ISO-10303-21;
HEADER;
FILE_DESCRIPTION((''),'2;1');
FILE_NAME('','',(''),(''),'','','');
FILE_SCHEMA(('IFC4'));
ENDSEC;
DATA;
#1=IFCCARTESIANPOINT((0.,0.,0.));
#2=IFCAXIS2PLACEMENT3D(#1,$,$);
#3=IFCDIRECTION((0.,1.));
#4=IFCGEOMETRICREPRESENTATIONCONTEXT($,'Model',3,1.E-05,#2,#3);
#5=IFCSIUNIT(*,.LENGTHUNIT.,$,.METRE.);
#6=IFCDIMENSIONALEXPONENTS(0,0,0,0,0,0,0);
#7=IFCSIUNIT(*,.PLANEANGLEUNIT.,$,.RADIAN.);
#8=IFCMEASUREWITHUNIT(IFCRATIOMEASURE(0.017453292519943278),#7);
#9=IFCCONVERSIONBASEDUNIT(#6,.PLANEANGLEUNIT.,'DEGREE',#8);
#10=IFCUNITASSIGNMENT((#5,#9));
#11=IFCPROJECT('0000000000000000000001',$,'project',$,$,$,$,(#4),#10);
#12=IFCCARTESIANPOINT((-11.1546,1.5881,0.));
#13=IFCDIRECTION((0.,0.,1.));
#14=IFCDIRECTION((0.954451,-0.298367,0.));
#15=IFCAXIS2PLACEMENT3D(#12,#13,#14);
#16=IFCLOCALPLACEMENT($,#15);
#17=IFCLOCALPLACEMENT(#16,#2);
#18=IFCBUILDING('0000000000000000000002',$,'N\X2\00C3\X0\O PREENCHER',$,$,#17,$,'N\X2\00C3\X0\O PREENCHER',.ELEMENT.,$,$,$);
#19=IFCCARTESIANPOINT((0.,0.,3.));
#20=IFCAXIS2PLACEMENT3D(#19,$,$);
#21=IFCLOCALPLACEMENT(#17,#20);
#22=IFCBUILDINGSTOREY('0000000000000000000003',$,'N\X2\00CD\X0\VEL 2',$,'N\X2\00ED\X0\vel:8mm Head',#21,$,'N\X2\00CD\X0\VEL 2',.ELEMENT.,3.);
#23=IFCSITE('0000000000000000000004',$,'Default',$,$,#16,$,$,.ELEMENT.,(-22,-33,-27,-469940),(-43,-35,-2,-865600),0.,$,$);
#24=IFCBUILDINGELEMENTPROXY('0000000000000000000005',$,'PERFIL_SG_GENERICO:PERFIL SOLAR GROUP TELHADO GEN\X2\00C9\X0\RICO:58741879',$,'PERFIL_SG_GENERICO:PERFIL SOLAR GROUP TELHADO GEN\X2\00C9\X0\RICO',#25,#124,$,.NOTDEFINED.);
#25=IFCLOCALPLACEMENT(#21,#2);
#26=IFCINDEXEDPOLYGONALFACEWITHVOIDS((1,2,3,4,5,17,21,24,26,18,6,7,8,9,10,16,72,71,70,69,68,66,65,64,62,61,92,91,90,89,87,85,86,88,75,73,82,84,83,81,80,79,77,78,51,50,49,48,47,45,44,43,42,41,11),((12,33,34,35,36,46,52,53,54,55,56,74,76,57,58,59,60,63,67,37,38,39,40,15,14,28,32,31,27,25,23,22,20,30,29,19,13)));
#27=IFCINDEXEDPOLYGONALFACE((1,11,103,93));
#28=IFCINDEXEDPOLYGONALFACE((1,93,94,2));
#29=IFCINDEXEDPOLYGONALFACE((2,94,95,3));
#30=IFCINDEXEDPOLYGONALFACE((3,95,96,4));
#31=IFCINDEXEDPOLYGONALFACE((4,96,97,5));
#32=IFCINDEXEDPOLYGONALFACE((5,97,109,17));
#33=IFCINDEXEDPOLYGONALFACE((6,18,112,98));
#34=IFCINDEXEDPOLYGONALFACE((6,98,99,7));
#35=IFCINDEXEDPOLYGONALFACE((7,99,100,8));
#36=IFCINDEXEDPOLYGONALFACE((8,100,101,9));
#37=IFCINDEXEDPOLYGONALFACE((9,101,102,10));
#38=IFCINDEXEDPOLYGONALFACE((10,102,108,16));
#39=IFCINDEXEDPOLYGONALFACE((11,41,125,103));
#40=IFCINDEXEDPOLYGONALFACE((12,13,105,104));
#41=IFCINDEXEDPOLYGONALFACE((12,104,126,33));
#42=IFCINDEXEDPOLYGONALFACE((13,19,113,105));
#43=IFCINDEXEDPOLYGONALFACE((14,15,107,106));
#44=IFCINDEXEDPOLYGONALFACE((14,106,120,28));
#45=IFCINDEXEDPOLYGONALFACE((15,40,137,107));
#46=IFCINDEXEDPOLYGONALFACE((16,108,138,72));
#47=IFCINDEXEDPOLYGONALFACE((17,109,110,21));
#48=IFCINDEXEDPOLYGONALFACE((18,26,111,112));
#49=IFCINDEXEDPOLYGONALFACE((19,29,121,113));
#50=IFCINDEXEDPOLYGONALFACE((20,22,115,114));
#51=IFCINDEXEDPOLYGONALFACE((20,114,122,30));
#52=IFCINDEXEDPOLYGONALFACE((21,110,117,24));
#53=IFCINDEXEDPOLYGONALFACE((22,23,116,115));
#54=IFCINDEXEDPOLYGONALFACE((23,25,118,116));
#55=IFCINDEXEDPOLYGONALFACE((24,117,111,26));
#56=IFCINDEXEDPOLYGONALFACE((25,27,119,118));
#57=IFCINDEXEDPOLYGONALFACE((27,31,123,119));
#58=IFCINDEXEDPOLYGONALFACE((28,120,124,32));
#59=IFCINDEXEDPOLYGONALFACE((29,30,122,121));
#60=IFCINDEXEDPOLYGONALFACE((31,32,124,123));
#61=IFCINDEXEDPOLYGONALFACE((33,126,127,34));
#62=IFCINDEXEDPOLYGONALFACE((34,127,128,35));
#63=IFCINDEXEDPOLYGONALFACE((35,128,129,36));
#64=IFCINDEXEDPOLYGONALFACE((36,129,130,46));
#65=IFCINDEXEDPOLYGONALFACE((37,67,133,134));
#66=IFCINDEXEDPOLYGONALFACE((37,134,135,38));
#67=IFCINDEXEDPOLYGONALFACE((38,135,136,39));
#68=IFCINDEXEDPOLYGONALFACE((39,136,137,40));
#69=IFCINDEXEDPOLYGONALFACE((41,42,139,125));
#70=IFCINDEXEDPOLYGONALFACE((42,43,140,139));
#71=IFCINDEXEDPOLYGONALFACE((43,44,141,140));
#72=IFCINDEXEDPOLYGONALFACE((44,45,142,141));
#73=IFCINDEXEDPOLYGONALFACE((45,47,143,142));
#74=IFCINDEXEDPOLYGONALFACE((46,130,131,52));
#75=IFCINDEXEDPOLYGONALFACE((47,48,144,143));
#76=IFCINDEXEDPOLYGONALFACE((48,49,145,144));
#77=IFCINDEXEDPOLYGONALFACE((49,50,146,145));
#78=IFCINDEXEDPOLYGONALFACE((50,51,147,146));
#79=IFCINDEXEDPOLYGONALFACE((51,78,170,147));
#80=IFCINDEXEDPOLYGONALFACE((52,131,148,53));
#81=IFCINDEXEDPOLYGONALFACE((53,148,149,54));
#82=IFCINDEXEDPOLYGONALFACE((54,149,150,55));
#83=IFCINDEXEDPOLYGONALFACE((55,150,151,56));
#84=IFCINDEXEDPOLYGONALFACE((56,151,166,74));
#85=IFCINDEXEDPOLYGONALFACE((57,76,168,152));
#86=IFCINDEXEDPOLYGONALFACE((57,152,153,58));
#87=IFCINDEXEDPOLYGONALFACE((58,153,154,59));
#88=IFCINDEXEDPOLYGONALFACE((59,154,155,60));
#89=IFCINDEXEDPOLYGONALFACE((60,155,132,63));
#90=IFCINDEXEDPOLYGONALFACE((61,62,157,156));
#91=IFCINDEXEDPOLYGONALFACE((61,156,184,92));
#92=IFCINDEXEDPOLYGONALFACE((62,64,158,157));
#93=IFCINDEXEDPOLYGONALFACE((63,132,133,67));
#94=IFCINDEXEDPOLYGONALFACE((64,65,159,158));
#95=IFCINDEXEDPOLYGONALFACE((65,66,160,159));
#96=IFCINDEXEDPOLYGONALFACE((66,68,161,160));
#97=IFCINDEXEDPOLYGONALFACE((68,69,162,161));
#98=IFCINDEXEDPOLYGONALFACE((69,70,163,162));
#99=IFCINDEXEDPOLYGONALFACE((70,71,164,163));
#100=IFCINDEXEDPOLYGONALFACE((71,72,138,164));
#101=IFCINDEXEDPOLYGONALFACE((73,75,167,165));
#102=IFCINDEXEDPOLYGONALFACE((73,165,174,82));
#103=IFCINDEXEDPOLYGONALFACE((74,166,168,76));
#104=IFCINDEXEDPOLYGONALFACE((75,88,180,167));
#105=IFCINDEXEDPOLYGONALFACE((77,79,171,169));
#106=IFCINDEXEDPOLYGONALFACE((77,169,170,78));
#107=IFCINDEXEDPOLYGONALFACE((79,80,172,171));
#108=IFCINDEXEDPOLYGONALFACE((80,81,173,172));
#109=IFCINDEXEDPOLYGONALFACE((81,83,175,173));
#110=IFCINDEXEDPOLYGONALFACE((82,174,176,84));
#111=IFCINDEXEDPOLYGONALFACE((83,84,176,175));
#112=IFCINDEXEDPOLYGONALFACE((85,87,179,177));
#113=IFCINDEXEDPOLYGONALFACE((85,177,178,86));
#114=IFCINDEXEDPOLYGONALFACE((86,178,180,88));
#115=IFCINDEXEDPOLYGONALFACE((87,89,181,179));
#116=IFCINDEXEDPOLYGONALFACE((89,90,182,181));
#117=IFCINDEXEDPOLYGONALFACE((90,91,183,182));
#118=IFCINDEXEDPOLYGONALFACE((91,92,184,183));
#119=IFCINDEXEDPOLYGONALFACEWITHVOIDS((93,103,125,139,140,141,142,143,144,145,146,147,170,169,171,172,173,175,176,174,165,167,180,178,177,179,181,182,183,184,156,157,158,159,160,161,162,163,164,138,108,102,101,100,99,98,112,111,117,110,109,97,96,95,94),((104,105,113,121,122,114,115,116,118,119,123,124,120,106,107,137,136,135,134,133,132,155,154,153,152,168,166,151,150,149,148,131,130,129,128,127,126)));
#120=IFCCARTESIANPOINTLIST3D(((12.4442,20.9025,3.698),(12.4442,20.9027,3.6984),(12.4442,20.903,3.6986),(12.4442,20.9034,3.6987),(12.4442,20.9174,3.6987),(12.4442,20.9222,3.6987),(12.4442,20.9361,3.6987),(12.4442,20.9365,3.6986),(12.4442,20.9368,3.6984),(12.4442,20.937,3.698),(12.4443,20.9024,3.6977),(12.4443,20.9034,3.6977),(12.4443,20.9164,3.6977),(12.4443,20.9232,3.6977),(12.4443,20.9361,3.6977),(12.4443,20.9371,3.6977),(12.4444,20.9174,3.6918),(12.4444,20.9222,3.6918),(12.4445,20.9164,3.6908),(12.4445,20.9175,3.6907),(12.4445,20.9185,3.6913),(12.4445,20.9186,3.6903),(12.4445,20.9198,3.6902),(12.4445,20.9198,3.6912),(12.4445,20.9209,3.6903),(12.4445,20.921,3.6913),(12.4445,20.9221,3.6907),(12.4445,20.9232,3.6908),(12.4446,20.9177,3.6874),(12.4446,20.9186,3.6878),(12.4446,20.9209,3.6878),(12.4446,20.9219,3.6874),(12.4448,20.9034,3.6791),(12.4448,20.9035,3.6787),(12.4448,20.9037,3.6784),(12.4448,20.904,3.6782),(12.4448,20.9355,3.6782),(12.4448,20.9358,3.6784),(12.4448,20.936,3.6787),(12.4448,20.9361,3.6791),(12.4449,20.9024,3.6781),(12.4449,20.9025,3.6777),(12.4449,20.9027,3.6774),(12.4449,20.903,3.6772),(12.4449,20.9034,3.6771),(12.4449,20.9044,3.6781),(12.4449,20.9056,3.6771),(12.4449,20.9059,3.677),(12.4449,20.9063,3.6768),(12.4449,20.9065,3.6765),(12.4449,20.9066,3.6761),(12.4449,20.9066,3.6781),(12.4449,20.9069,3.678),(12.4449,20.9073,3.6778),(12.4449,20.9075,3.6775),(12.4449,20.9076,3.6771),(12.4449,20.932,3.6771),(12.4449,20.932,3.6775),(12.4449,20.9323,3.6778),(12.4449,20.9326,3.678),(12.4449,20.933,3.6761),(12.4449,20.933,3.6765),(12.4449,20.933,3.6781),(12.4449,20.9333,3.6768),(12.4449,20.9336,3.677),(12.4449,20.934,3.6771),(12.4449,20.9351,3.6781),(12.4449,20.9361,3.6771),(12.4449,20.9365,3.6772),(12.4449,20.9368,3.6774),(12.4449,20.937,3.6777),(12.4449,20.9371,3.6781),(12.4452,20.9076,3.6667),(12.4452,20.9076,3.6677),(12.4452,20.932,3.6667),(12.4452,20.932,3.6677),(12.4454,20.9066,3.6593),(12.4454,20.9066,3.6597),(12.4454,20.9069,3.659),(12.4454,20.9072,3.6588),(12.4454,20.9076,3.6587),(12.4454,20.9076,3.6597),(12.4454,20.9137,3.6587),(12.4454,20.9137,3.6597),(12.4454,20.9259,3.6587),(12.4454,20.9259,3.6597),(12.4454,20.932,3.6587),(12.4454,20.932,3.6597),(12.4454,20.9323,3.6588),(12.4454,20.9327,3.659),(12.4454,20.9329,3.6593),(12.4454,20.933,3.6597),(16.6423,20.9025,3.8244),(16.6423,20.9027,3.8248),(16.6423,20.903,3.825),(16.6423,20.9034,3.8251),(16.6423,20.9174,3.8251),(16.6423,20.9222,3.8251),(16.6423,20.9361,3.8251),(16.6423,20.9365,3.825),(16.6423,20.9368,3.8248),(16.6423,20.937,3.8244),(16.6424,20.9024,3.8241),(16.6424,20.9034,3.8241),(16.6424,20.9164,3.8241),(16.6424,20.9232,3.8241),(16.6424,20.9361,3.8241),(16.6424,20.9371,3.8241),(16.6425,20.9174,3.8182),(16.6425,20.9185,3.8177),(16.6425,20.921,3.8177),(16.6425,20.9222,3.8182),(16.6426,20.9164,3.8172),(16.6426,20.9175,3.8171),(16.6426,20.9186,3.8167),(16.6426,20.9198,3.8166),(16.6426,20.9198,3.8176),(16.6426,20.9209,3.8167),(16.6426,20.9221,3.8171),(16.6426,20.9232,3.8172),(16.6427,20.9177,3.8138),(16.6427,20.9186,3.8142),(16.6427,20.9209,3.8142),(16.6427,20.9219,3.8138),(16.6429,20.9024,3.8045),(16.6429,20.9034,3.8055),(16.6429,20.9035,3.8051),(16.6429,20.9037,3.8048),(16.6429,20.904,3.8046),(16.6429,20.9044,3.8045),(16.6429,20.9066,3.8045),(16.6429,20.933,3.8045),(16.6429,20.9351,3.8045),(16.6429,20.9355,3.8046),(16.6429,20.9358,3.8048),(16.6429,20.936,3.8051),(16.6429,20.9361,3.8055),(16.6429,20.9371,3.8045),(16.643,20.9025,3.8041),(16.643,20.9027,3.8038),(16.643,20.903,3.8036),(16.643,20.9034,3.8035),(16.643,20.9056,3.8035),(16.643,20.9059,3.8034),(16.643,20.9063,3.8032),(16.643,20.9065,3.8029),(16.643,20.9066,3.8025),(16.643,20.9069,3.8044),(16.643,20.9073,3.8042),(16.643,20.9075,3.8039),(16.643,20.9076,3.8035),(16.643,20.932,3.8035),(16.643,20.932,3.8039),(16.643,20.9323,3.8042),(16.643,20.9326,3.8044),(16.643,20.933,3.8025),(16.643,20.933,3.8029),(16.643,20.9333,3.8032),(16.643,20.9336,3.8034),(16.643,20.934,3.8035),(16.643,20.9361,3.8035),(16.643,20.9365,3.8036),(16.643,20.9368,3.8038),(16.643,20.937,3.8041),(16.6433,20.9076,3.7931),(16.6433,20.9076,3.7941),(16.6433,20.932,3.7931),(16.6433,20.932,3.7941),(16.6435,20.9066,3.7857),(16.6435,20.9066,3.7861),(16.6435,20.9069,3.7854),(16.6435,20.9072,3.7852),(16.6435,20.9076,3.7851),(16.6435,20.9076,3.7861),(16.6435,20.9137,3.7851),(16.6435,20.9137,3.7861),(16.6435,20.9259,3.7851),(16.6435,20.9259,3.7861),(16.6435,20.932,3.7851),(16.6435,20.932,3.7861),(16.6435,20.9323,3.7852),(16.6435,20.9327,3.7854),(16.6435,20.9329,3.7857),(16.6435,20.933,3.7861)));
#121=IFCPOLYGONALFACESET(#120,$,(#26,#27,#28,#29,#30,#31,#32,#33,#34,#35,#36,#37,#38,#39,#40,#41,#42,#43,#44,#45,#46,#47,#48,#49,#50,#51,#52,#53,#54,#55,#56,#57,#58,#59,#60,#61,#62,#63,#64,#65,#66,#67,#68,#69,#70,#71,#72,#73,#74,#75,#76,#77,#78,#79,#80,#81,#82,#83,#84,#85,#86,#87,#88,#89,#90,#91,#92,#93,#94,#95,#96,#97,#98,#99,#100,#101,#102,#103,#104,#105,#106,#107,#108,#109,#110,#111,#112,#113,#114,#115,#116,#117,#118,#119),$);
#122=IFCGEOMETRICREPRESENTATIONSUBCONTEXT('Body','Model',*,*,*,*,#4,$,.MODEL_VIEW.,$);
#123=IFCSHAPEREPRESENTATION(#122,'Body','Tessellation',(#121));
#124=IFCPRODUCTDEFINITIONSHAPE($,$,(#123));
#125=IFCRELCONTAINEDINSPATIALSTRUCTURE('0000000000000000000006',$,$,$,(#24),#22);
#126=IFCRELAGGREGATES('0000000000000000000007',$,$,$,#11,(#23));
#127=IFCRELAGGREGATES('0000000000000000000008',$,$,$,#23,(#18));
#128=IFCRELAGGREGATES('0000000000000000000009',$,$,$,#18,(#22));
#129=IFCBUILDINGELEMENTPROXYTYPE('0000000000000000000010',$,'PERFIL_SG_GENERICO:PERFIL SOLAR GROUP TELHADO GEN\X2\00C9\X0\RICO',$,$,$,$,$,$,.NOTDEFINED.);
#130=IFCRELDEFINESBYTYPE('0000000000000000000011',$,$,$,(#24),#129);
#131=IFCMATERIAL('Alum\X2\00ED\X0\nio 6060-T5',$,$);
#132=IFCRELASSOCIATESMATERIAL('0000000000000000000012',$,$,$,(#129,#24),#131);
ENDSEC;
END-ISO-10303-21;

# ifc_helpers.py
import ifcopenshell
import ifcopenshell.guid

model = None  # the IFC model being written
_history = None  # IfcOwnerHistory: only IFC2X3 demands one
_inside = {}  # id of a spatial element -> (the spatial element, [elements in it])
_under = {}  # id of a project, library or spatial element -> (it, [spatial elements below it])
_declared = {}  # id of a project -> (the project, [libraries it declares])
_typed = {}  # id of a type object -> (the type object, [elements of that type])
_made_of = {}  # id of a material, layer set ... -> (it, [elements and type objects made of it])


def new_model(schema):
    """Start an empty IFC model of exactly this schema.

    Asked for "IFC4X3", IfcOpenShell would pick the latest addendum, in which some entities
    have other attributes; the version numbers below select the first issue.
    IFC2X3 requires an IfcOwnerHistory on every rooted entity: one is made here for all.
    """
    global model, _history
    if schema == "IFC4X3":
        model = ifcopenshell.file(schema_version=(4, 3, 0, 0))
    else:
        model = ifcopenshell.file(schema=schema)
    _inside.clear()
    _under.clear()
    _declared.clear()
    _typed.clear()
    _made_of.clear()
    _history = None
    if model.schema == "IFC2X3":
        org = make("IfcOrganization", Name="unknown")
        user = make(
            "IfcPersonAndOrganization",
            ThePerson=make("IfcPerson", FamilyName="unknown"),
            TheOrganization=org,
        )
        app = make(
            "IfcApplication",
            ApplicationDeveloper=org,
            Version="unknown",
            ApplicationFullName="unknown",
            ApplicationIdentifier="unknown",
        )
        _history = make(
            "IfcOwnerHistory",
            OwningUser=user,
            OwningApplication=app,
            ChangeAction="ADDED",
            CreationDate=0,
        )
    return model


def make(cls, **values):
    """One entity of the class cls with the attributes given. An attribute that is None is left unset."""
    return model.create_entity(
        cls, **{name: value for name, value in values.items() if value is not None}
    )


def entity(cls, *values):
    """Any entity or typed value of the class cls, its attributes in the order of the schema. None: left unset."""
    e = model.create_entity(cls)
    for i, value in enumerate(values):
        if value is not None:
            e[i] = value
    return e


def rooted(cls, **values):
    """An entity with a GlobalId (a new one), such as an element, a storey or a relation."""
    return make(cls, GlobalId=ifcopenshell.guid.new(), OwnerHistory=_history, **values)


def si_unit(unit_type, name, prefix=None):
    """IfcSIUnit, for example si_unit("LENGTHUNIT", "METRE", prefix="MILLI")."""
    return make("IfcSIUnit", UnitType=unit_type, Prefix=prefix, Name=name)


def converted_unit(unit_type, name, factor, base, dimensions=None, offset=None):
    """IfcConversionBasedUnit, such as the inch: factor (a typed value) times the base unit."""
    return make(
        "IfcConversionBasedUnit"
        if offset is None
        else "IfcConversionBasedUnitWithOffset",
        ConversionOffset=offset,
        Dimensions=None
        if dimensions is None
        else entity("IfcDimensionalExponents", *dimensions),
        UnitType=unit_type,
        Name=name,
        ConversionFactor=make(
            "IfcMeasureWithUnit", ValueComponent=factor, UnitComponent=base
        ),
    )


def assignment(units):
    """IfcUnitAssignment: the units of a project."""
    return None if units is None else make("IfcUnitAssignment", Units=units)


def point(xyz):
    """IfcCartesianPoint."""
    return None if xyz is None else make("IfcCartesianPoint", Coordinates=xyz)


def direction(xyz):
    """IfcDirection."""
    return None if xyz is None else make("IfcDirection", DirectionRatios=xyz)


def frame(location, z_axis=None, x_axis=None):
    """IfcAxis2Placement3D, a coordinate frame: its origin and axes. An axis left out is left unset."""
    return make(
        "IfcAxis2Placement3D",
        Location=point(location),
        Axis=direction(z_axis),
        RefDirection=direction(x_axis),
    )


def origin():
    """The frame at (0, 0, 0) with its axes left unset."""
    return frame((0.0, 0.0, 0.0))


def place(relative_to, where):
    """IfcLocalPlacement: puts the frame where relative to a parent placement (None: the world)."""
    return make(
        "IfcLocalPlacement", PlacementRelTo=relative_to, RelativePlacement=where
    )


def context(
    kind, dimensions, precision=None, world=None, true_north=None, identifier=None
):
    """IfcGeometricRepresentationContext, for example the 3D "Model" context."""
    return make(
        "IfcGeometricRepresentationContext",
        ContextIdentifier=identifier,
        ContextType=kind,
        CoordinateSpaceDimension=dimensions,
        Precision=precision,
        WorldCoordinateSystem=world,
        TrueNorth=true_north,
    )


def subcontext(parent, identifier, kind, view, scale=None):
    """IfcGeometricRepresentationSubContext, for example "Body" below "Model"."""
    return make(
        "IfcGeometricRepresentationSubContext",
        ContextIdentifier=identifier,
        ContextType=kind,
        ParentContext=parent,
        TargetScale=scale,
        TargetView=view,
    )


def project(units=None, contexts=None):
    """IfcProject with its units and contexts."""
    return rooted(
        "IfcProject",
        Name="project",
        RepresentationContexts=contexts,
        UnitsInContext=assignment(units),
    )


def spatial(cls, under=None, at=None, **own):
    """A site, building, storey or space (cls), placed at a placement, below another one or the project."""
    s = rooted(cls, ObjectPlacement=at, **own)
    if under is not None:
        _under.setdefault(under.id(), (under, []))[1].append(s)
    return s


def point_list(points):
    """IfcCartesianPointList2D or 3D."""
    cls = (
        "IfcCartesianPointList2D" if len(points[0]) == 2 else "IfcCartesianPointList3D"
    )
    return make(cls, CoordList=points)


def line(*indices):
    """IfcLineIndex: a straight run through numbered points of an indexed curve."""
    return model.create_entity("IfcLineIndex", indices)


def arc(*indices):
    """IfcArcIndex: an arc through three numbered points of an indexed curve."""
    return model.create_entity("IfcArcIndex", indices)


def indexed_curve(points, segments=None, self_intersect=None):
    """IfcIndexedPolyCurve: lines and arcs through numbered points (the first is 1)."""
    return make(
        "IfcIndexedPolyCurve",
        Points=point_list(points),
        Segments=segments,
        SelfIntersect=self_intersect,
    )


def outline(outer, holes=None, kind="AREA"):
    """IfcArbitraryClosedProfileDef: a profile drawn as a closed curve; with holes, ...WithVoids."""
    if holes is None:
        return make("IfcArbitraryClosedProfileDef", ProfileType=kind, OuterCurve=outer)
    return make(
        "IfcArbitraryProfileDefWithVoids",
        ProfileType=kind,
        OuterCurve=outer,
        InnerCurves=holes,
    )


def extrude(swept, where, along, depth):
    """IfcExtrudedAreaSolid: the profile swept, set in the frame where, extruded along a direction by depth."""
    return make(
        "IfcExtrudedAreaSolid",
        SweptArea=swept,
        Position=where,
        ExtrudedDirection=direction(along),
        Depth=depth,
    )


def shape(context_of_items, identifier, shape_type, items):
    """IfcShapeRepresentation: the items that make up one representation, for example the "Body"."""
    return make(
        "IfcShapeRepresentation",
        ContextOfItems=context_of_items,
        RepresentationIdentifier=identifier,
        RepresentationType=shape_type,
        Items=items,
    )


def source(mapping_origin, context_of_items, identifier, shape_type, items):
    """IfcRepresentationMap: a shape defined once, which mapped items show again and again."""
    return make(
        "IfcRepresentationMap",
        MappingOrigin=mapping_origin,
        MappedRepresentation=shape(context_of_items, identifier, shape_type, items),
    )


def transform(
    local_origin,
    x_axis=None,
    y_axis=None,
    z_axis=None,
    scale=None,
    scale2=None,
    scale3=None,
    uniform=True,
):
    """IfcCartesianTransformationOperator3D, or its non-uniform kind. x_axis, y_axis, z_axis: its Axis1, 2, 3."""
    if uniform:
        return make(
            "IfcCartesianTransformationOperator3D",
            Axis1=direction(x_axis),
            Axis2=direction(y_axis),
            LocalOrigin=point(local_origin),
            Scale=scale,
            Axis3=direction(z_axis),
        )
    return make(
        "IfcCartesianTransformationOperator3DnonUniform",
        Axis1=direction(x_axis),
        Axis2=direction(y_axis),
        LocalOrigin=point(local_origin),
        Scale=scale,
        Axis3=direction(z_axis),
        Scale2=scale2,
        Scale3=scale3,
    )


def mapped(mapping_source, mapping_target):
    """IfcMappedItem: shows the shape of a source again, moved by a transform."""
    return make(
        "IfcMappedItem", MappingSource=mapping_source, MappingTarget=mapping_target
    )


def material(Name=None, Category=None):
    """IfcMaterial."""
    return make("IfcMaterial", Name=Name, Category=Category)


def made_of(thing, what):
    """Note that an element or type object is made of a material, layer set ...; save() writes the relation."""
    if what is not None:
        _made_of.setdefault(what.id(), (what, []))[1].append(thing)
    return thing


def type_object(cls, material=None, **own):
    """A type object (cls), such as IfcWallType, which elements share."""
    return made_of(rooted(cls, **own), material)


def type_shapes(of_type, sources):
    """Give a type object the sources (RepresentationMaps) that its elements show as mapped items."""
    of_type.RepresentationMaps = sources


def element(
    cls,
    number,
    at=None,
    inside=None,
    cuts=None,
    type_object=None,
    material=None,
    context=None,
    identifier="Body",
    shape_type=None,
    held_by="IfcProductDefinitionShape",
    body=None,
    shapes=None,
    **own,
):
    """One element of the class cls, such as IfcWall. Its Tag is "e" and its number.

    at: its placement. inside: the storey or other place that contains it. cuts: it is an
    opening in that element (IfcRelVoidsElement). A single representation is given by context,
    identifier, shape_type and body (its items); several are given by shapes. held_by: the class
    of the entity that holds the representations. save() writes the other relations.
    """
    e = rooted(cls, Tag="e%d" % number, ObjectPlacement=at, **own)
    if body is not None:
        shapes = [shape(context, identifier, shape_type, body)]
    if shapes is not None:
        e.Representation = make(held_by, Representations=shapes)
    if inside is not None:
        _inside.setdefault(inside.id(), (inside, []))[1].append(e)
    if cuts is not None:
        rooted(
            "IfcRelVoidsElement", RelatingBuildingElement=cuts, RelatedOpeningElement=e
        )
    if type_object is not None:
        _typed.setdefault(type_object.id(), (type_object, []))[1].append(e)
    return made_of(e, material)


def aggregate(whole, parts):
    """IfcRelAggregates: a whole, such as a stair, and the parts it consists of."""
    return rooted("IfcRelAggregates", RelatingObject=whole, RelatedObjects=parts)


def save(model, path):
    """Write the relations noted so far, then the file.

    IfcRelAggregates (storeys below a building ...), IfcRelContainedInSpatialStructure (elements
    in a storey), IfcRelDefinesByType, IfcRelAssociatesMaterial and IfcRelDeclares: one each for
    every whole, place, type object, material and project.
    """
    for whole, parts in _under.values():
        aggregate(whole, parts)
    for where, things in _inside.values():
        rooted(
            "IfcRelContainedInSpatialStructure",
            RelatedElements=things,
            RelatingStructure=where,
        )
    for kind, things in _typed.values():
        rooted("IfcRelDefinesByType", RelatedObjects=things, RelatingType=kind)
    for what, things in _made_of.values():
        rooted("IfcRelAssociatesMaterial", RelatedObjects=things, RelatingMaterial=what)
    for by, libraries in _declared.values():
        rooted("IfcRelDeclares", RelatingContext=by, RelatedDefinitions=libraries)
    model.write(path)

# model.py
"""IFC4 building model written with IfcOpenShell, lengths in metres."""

from ifc_helpers import new_model, entity, si_unit, converted_unit, direction, frame, origin, place, context, subcontext, project, spatial, line, arc, indexed_curve, outline, extrude, source, transform, mapped, material, type_object, type_shapes, element, save


model = new_model("IFC4")

# Units and contexts
model_context = context("Model", 3, precision=1e-05, world=origin(), true_north=direction((0.0, 1.0)))
body_context = subcontext(model_context, "Body", "Model", "MODEL_VIEW")
ifc_project = project(units=[si_unit("LENGTHUNIT", "METRE"), converted_unit("PLANEANGLEUNIT", "DEGREE", entity("IfcRatioMeasure", 0.017453292519943278), si_unit("PLANEANGLEUNIT", "RADIAN"), dimensions=[0, 0, 0, 0, 0, 0, 0])], contexts=[model_context])

# Site, building, storey
site_placement = place(None, frame((-11.1546, 1.5881, 0.0), z_axis=(0.0, 0.0, 1.0), x_axis=(0.954451, -0.298367, 0.0)))
site = spatial("IfcSite", under=ifc_project, at=site_placement, Name="Default", CompositionType="ELEMENT", RefLatitude=(-22, -33, -27, -469940), RefLongitude=(-43, -35, -2, -865600), RefElevation=0.0)
building_placement = place(site_placement, origin())
building = spatial("IfcBuilding", under=site, at=building_placement, Name="NÃO PREENCHER", LongName="NÃO PREENCHER", CompositionType="ELEMENT")
storey_placement = place(building_placement, frame((0.0, 0.0, 3.0)))
storey = spatial("IfcBuildingStorey", under=building, at=storey_placement, Name="NÍVEL 2", ObjectType="Nível:8mm Head", LongName="NÍVEL 2", CompositionType="ELEMENT", Elevation=3.0)

# Building element proxy
ifc_material_1 = material(Name="Alumínio 6060-T5")
building_element_proxy_type_1 = type_object("IfcBuildingElementProxyType", Name="PERFIL_SG_GENERICO:PERFIL SOLAR GROUP TELHADO GENÉRICO", PredefinedType="NOTDEFINED", material=ifc_material_1)
shared_shape_1 = source(origin(), body_context, "Body", "SweptSolid", [
    extrude(outline(indexed_curve([(-0.0122, -0.0169), (-0.0061, -0.0169), (-0.0061, -0.0159), (-0.0122, -0.0159), (-0.0122, -0.0089), (0.0122, -0.0089), (0.0122, -0.0159), (0.0061, -0.0159), (0.0061, -0.0169), (0.0122, -0.0169), (0.0129, -0.0166), (0.0132, -0.0159), (0.0132, 0.0005), (0.0135, 0.0012), (0.0142, 0.0015), (0.0164, 0.0015), (0.0171, 0.0018), (0.0174, 0.0025), (0.0174, 0.0221), (0.0171, 0.0228), (0.0164, 0.0231), (0.0024, 0.0231), (0.0024, 0.0162), (0.0, 0.0156), (-0.0024, 0.0162), (-0.0024, 0.0231), (-0.0164, 0.0231), (-0.0171, 0.0228), (-0.0174, 0.0221), (-0.0174, 0.0025), (-0.0171, 0.0018), (-0.0164, 0.0015), (-0.0142, 0.0015), (-0.0135, 0.0012), (-0.0132, 0.0005), (-0.0132, -0.0159), (-0.0129, -0.0166)], segments=[line(1, 2, 3, 4, 5, 6, 7, 8, 9, 10), arc(10, 11, 12), line(12, 13), arc(13, 14, 15), line(15, 16), arc(16, 17, 18), line(18, 19), arc(19, 20, 21), line(21, 22, 23), arc(23, 24, 25), line(25, 26, 27), arc(27, 28, 29), line(29, 30), arc(30, 31, 32), line(32, 33), arc(33, 34, 35), line(35, 36), arc(36, 37, 1)], self_intersect=False), holes=[indexed_curve([(-0.0122, -0.0079), (-0.0122, 0.0015), (-0.0125, 0.0022), (-0.0132, 0.0025), (-0.0154, 0.0025), (-0.0161, 0.0028), (-0.0164, 0.0035), (-0.0164, 0.0221), (-0.0034, 0.0221), (-0.0034, 0.0152), (-0.0021, 0.0118), (-0.0012, 0.0122), (-0.0023, 0.0151), (0.0, 0.0146), (0.0023, 0.0151), (0.0012, 0.0122), (0.0021, 0.0118), (0.0034, 0.0152), (0.0034, 0.0221), (0.0164, 0.0221), (0.0164, 0.0035), (0.0161, 0.0028), (0.0154, 0.0025), (0.0132, 0.0025), (0.0125, 0.0022), (0.0122, 0.0015), (0.0122, -0.0079)], segments=[line(1, 2), arc(2, 3, 4), line(4, 5), arc(5, 6, 7), line(7, 8, 9, 10, 11, 12, 13), arc(13, 14, 15), line(15, 16, 17, 18, 19, 20, 21), arc(21, 22, 23), line(23, 24), arc(24, 25, 26), line(26, 27, 1)], self_intersect=False)]), frame((0.0, 0.0, 0.0169), z_axis=(1.0, 0.0, 0.0), x_axis=(0.0, 1.0, 0.0)), (0.0, 0.0, 1.0), 4.2),
])
type_shapes(building_element_proxy_type_1, [shared_shape_1])
for number, where, z_axis, x_axis, name in (
    (1, (12.4454, 20.9198, 3.6587), (-0.030095, 0.0, 0.999547), (0.999547, 0.0, 0.030095), "PERFIL_SG_GENERICO:PERFIL SOLAR GROUP TELHADO GENÉRICO:58741879"),
):
    element("IfcBuildingElementProxy", number, at=place(storey_placement, frame(where, z_axis=z_axis, x_axis=x_axis)), inside=storey, type_object=building_element_proxy_type_1, material=ifc_material_1, Name=name, ObjectType="PERFIL_SG_GENERICO:PERFIL SOLAR GROUP TELHADO GENÉRICO", PredefinedType="NOTDEFINED", context=body_context, shape_type="MappedRepresentation", body=[
        mapped(shared_shape_1, transform((0.0, 0.0, 0.0), scale=1.0)),
    ])

save(model, "model.ifc")
